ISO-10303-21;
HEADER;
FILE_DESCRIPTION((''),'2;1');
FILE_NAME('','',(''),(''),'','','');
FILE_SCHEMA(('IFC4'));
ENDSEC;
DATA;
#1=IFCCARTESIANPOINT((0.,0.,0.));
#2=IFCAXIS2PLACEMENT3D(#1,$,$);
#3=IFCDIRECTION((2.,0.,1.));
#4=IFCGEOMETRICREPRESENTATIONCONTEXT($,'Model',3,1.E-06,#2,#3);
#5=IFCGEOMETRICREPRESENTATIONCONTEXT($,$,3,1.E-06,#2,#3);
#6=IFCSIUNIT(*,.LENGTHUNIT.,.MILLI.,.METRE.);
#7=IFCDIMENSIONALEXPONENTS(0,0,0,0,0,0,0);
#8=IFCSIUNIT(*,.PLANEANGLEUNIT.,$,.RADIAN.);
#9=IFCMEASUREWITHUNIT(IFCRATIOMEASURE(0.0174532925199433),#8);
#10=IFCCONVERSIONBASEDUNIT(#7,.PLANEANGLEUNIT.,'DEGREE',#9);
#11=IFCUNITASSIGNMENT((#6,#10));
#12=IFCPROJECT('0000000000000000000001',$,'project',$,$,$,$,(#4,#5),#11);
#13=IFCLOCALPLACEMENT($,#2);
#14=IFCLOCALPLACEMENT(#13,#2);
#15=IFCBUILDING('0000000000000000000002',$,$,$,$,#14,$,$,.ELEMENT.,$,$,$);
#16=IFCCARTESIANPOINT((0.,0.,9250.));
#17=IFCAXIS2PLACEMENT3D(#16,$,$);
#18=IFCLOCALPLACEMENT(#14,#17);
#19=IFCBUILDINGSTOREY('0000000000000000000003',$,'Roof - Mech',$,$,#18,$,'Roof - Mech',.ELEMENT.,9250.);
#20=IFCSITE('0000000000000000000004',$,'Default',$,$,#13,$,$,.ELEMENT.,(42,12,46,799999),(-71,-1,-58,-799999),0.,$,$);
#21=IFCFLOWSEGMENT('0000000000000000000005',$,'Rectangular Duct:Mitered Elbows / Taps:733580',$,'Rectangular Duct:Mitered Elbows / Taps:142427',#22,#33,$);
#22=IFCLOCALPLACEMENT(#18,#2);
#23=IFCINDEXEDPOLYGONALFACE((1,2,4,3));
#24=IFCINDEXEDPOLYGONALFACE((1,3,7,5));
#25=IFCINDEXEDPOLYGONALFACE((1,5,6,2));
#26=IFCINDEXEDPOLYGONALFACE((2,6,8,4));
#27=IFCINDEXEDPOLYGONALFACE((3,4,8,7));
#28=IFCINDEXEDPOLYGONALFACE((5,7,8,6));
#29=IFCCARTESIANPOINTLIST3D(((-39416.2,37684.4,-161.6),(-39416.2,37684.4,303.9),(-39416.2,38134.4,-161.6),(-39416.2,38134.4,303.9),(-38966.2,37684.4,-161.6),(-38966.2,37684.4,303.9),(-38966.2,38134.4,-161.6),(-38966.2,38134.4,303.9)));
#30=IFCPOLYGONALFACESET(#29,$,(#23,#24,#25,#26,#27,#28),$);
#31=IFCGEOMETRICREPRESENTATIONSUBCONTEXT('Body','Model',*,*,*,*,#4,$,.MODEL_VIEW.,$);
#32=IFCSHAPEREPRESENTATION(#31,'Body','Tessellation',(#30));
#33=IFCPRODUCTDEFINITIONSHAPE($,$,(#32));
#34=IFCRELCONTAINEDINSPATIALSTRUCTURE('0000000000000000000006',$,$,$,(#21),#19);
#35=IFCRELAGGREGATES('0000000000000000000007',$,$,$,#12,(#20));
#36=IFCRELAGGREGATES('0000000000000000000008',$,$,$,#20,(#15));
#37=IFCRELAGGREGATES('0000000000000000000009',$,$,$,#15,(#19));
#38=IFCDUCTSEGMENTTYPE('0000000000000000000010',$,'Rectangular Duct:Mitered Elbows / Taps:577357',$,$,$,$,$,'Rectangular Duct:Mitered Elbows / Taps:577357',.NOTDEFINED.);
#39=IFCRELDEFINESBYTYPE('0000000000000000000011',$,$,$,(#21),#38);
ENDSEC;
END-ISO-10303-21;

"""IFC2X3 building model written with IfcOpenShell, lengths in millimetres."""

from ifc_helpers import new_model, entity, si_unit, converted_unit, direction, frame, origin, origin_2d_with_axis, place, context, subcontext, project, spatial, rectangle, extrude, type_object, element, save


model = new_model("IFC2X3")

# Units and contexts
model_context = context("Model", 3, precision=1e-06, world=origin(), true_north=direction((2.0, 0.0, 1.0)))
context_of_model = context(None, 3, precision=1e-06, world=origin(), true_north=direction((2.0, 0.0, 1.0)))
body_context = subcontext(model_context, "Body", "Model", "MODEL_VIEW")
ifc_project = project(units=[si_unit("LENGTHUNIT", "METRE", prefix="MILLI"), converted_unit("PLANEANGLEUNIT", "DEGREE", entity("IfcRatioMeasure", 0.0174532925199433), si_unit("PLANEANGLEUNIT", "RADIAN"), dimensions=[0, 0, 0, 0, 0, 0, 0])], contexts=[model_context, context_of_model])

# Site, building, storey
site_placement = place(None, origin())
site = spatial("IfcSite", under=ifc_project, at=site_placement, Name="Default", CompositionType="ELEMENT", RefLatitude=(42, 12, 46, 799999), RefLongitude=(-71, -1, -58, -799999), RefElevation=0.0)
building_placement = place(site_placement, origin())
building = spatial("IfcBuilding", under=site, at=building_placement, CompositionType="ELEMENT")
storey_placement = place(building_placement, frame((0.0, 0.0, 9250.0)))
storey = spatial("IfcBuildingStorey", under=building, at=storey_placement, Name="Roof - Mech", LongName="Roof - Mech", CompositionType="ELEMENT", Elevation=9250.0)

# Flow segment
duct_segment_type = type_object("IfcDuctSegmentType", Name="Rectangular Duct:Mitered Elbows / Taps:577357", ElementType="Rectangular Duct:Mitered Elbows / Taps:577357", PredefinedType="NOTDEFINED")
flow_segment_placement = place(storey_placement, origin())
element("IfcFlowSegment", 1, at=flow_segment_placement, inside=storey, type_object=duct_segment_type, Name="Rectangular Duct:Mitered Elbows / Taps:733580", ObjectType="Rectangular Duct:Mitered Elbows / Taps:142427", context=body_context, shape_type="SweptSolid", body=[
    extrude(rectangle(XDim=450.0, YDim=450.0, at=origin_2d_with_axis()), frame((-39191.2, 37909.4, -161.6)), (0.0, 0.0, 1.0), 465.5),
])

save(model, "model.ifc")
